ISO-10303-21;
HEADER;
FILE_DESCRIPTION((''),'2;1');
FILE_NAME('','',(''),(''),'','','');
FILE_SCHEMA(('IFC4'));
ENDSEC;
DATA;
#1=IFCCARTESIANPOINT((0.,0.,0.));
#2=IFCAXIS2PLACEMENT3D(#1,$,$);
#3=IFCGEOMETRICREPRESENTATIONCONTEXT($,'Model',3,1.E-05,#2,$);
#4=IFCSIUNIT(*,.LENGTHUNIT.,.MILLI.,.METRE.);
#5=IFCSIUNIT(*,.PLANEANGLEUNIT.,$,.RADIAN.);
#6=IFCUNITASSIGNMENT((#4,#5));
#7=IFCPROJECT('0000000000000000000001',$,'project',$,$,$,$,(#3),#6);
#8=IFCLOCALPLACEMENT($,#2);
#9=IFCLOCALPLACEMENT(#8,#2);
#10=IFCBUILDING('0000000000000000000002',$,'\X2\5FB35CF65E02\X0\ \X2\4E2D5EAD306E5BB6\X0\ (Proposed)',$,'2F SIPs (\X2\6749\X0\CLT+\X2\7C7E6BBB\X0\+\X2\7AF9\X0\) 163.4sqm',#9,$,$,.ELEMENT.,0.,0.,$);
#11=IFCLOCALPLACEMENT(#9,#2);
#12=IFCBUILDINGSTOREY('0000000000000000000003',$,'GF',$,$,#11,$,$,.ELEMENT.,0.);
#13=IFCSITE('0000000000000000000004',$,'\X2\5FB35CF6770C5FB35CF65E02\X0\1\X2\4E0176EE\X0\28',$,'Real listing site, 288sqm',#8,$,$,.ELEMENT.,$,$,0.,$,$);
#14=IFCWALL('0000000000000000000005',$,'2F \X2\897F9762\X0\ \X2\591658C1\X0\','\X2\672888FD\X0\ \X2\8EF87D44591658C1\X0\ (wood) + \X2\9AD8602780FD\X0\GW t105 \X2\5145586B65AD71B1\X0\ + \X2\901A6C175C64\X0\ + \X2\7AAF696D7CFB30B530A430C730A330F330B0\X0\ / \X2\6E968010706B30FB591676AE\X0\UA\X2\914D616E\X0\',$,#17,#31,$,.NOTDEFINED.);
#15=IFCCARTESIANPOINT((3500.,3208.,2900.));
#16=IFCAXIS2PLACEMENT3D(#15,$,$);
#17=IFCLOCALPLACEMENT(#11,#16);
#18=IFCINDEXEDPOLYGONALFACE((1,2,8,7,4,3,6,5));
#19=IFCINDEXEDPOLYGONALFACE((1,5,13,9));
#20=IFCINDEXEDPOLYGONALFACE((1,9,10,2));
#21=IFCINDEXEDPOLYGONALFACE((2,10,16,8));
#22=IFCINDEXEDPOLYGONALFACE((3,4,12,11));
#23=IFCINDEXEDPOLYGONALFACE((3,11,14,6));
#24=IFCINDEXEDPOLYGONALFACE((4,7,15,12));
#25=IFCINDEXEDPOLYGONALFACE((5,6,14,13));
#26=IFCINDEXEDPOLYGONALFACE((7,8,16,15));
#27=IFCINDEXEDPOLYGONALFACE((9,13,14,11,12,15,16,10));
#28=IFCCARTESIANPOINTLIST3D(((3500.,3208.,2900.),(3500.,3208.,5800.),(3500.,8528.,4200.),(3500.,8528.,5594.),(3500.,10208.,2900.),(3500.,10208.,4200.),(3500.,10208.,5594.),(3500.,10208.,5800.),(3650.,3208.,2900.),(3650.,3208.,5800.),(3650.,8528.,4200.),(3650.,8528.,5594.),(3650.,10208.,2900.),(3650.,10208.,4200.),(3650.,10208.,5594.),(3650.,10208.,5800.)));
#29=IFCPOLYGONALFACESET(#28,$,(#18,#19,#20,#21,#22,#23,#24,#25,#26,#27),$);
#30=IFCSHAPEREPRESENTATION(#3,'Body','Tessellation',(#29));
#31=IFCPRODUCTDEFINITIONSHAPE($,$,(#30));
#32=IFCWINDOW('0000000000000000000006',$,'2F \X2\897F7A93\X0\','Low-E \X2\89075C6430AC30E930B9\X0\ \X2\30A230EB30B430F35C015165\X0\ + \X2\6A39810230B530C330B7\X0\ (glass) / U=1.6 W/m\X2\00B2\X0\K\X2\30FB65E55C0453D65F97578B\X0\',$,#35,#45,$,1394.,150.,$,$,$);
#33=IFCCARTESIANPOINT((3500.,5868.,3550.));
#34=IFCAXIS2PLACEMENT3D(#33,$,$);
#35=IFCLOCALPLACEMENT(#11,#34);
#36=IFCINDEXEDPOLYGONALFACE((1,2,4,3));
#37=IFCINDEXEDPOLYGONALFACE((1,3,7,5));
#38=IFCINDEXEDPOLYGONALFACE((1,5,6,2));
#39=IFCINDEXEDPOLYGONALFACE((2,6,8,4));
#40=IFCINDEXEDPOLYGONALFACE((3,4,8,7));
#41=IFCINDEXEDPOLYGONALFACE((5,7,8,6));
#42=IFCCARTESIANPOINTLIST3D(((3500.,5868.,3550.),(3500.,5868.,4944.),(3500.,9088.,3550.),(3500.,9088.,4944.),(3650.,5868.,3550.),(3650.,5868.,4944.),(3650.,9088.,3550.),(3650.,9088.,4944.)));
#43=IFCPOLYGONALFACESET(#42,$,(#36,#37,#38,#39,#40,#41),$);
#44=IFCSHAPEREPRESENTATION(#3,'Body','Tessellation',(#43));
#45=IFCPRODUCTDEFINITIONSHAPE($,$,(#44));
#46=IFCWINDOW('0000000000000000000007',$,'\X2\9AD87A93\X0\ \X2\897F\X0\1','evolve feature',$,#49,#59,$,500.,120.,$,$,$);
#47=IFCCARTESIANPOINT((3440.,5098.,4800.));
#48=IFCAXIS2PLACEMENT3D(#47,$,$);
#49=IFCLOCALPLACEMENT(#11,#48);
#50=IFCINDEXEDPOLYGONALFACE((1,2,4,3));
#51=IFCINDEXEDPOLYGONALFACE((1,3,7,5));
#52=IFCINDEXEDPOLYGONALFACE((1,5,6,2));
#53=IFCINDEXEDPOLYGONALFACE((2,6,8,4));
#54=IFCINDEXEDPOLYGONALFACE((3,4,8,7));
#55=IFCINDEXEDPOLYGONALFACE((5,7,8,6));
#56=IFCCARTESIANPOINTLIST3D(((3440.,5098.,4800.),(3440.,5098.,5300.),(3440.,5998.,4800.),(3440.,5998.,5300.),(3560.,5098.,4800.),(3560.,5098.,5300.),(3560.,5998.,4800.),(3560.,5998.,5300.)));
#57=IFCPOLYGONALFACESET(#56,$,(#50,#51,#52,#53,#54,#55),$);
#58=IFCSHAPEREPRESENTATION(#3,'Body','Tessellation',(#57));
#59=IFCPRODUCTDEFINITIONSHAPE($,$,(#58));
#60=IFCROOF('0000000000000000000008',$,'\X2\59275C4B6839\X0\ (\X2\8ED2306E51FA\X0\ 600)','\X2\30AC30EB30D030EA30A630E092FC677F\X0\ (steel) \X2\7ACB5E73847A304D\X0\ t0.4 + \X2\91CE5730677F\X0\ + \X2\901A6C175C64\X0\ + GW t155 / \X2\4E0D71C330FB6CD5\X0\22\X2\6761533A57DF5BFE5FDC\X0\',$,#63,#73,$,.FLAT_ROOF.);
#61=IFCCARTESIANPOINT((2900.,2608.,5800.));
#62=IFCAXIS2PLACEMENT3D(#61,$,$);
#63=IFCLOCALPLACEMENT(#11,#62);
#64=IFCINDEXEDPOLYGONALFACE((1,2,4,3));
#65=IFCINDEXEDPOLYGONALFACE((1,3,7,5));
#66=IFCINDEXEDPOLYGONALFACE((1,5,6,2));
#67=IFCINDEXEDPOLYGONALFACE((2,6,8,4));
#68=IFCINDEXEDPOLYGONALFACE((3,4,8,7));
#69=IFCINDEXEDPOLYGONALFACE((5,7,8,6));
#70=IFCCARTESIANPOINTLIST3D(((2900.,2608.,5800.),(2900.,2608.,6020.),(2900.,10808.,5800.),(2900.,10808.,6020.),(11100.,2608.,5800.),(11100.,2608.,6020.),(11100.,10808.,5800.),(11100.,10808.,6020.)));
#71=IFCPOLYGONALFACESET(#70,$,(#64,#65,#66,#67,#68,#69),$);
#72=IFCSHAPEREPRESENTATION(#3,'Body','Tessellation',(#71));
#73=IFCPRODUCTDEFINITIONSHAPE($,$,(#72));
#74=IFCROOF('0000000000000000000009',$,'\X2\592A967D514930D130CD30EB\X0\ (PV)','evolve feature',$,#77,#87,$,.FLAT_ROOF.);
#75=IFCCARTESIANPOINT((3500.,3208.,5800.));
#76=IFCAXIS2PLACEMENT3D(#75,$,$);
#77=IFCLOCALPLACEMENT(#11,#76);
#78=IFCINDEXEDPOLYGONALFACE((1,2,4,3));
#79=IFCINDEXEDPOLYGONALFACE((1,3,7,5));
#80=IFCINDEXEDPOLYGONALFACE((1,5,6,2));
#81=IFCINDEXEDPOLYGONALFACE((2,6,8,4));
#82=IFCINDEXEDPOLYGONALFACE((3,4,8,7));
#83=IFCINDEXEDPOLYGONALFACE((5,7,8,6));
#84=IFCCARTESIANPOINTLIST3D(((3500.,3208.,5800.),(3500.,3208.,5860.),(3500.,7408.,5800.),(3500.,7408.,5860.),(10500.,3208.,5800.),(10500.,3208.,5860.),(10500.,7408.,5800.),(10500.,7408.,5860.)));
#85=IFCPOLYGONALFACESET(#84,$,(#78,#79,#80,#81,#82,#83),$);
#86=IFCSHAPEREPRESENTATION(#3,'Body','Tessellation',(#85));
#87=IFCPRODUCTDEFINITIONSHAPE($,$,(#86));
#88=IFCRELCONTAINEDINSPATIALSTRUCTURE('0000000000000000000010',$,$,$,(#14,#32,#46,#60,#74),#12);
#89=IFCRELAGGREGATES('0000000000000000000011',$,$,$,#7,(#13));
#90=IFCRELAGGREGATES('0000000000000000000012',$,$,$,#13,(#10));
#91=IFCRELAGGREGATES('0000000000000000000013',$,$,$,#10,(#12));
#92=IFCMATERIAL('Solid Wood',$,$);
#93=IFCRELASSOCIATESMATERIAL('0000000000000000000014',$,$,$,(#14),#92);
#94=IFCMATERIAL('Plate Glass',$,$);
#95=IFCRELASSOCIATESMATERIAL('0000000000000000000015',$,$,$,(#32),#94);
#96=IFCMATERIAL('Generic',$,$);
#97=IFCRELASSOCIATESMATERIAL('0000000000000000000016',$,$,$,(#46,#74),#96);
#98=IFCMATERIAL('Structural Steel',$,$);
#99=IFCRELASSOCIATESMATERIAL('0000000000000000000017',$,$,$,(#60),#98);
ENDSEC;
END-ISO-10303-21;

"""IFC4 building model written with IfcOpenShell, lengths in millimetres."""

from ifc_helpers import new_model, si_unit, frame, frame_2d, origin, place, context, project, spatial, rectangle, extrude, material, element, fill, save


model = new_model("IFC4")

# Units and contexts
model_context = context("Model", 3, precision=1e-05, world=origin())
ifc_project = project(units=[si_unit("LENGTHUNIT", "METRE", prefix="MILLI"), si_unit("PLANEANGLEUNIT", "RADIAN")], contexts=[model_context])

# Site, building, storey
site_placement = place(None, origin())
site = spatial("IfcSite", under=ifc_project, at=site_placement, Name="徳島県徳島市1丁目28", ObjectType="Real listing site, 288sqm", CompositionType="ELEMENT", RefElevation=0.0)
building_placement = place(site_placement, origin())
building = spatial("IfcBuilding", under=site, at=building_placement, Name="徳島市 中庭の家 (Proposed)", ObjectType="2F SIPs (杉CLT+籾殻+竹) 163.4sqm", CompositionType="ELEMENT", ElevationOfRefHeight=0.0, ElevationOfTerrain=0.0)
storey_placement = place(building_placement, origin())
storey = spatial("IfcBuildingStorey", under=building, at=storey_placement, Name="GF", CompositionType="ELEMENT", Elevation=0.0)

# Shared definitions
ifc_material_1 = material(Name="Solid Wood")
ifc_material_2 = material(Name="Generic")

# Shared definitions
ifc_material_3 = material(Name="Plate Glass")

# Wall, openings, windows
wall_1_placement = place(storey_placement, frame((3500.0, 3208.0, 2900.0)))
wall_1 = element("IfcWall", 1, at=wall_1_placement, inside=storey, material=ifc_material_1, Name="2F 西面 外壁", Description="木製 軸組外壁 (wood) + 高性能GW t105 充填断熱 + 通気層 + 窯業系サイディング / 準耐火・外皮UA配慮", PredefinedType="NOTDEFINED", context=model_context, shape_type="SweptSolid", body=[
    extrude(rectangle(XDim=150.0, YDim=7000.0, at=frame_2d((75.0, 3500.0))), frame((3500.0, 3208.0, 2900.0)), (0.0, 0.0, 1.0), 2900.0),
])
opening_1_placement = place(storey_placement, frame((3500.0, 5868.0, 3550.0)))
opening_1 = element("IfcOpeningElement", 2, at=opening_1_placement, cuts=wall_1, PredefinedType="NOTDEFINED", context=model_context, shape_type="SweptSolid", body=[
    extrude(rectangle(XDim=150.0, YDim=3220.0, at=frame_2d((75.0, 1610.0))), frame((3500.0, 5868.0, 3550.0)), (0.0, 0.0, 1.0), 1394.0),
])
opening_2_placement = place(storey_placement, frame((3440.0, 5098.0, 4800.0)))
opening_2 = element("IfcOpeningElement", 3, at=opening_2_placement, cuts=wall_1, PredefinedType="NOTDEFINED", context=model_context, shape_type="SweptSolid", body=[
    extrude(rectangle(XDim=120.0, YDim=900.0, at=frame_2d((60.0, 450.0))), frame((3440.0, 5098.0, 4800.0)), (0.0, 0.0, 1.0), 500.0),
])
window_1_placement = place(storey_placement, frame((3500.0, 5868.0, 3550.0)))
window_1 = element("IfcWindow", 4, at=window_1_placement, inside=storey, material=ifc_material_3, Name="2F 西窓", Description="Low-E 複層ガラス アルゴン封入 + 樹脂サッシ (glass) / U=1.6 W/m²K・日射取得型", OverallHeight=1394.0, OverallWidth=150.0, context=model_context, shape_type="SweptSolid", body=[
    extrude(rectangle(XDim=150.0, YDim=3220.0, at=frame_2d((75.0, 1610.0))), frame((3500.0, 5868.0, 3550.0)), (0.0, 0.0, 1.0), 1394.0),
])
fill(opening_1, window_1)
window_2_placement = place(storey_placement, frame((3440.0, 5098.0, 4800.0)))
window_2 = element("IfcWindow", 5, at=window_2_placement, inside=storey, material=ifc_material_2, Name="高窓 西1", Description="evolve feature", OverallHeight=500.0, OverallWidth=120.0, context=model_context, shape_type="SweptSolid", body=[
    extrude(rectangle(XDim=120.0, YDim=900.0, at=frame_2d((60.0, 450.0))), frame((3440.0, 5098.0, 4800.0)), (0.0, 0.0, 1.0), 500.0),
])
fill(opening_2, window_2)

# Roofs
ifc_material_4 = material(Name="Structural Steel")
roof_1_placement = place(storey_placement, frame((2900.0, 2608.0, 5800.0)))
element("IfcRoof", 6, at=roof_1_placement, inside=storey, material=ifc_material_4, Name="大屋根 (軒の出 600)", Description="ガルバリウム鋼板 (steel) 立平葺き t0.4 + 野地板 + 通気層 + GW t155 / 不燃・法22条区域対応", PredefinedType="FLAT_ROOF", context=model_context, shape_type="SweptSolid", body=[
    extrude(rectangle(XDim=8200.0, YDim=8200.0, at=frame_2d((4100.0, 4100.0))), frame((2900.0, 2608.0, 5800.0)), (0.0, 0.0, 1.0), 220.0),
])
roof_2_placement = place(storey_placement, frame((3500.0, 3208.0, 5800.0)))
element("IfcRoof", 7, at=roof_2_placement, inside=storey, material=ifc_material_2, Name="太陽光パネル (PV)", Description="evolve feature", PredefinedType="FLAT_ROOF", context=model_context, shape_type="SweptSolid", body=[
    extrude(rectangle(XDim=7000.0, YDim=4200.0, at=frame_2d((3500.0, 2100.0))), frame((3500.0, 3208.0, 5800.0)), (0.0, 0.0, 1.0), 60.0),
])

save(model, "model.ifc")
